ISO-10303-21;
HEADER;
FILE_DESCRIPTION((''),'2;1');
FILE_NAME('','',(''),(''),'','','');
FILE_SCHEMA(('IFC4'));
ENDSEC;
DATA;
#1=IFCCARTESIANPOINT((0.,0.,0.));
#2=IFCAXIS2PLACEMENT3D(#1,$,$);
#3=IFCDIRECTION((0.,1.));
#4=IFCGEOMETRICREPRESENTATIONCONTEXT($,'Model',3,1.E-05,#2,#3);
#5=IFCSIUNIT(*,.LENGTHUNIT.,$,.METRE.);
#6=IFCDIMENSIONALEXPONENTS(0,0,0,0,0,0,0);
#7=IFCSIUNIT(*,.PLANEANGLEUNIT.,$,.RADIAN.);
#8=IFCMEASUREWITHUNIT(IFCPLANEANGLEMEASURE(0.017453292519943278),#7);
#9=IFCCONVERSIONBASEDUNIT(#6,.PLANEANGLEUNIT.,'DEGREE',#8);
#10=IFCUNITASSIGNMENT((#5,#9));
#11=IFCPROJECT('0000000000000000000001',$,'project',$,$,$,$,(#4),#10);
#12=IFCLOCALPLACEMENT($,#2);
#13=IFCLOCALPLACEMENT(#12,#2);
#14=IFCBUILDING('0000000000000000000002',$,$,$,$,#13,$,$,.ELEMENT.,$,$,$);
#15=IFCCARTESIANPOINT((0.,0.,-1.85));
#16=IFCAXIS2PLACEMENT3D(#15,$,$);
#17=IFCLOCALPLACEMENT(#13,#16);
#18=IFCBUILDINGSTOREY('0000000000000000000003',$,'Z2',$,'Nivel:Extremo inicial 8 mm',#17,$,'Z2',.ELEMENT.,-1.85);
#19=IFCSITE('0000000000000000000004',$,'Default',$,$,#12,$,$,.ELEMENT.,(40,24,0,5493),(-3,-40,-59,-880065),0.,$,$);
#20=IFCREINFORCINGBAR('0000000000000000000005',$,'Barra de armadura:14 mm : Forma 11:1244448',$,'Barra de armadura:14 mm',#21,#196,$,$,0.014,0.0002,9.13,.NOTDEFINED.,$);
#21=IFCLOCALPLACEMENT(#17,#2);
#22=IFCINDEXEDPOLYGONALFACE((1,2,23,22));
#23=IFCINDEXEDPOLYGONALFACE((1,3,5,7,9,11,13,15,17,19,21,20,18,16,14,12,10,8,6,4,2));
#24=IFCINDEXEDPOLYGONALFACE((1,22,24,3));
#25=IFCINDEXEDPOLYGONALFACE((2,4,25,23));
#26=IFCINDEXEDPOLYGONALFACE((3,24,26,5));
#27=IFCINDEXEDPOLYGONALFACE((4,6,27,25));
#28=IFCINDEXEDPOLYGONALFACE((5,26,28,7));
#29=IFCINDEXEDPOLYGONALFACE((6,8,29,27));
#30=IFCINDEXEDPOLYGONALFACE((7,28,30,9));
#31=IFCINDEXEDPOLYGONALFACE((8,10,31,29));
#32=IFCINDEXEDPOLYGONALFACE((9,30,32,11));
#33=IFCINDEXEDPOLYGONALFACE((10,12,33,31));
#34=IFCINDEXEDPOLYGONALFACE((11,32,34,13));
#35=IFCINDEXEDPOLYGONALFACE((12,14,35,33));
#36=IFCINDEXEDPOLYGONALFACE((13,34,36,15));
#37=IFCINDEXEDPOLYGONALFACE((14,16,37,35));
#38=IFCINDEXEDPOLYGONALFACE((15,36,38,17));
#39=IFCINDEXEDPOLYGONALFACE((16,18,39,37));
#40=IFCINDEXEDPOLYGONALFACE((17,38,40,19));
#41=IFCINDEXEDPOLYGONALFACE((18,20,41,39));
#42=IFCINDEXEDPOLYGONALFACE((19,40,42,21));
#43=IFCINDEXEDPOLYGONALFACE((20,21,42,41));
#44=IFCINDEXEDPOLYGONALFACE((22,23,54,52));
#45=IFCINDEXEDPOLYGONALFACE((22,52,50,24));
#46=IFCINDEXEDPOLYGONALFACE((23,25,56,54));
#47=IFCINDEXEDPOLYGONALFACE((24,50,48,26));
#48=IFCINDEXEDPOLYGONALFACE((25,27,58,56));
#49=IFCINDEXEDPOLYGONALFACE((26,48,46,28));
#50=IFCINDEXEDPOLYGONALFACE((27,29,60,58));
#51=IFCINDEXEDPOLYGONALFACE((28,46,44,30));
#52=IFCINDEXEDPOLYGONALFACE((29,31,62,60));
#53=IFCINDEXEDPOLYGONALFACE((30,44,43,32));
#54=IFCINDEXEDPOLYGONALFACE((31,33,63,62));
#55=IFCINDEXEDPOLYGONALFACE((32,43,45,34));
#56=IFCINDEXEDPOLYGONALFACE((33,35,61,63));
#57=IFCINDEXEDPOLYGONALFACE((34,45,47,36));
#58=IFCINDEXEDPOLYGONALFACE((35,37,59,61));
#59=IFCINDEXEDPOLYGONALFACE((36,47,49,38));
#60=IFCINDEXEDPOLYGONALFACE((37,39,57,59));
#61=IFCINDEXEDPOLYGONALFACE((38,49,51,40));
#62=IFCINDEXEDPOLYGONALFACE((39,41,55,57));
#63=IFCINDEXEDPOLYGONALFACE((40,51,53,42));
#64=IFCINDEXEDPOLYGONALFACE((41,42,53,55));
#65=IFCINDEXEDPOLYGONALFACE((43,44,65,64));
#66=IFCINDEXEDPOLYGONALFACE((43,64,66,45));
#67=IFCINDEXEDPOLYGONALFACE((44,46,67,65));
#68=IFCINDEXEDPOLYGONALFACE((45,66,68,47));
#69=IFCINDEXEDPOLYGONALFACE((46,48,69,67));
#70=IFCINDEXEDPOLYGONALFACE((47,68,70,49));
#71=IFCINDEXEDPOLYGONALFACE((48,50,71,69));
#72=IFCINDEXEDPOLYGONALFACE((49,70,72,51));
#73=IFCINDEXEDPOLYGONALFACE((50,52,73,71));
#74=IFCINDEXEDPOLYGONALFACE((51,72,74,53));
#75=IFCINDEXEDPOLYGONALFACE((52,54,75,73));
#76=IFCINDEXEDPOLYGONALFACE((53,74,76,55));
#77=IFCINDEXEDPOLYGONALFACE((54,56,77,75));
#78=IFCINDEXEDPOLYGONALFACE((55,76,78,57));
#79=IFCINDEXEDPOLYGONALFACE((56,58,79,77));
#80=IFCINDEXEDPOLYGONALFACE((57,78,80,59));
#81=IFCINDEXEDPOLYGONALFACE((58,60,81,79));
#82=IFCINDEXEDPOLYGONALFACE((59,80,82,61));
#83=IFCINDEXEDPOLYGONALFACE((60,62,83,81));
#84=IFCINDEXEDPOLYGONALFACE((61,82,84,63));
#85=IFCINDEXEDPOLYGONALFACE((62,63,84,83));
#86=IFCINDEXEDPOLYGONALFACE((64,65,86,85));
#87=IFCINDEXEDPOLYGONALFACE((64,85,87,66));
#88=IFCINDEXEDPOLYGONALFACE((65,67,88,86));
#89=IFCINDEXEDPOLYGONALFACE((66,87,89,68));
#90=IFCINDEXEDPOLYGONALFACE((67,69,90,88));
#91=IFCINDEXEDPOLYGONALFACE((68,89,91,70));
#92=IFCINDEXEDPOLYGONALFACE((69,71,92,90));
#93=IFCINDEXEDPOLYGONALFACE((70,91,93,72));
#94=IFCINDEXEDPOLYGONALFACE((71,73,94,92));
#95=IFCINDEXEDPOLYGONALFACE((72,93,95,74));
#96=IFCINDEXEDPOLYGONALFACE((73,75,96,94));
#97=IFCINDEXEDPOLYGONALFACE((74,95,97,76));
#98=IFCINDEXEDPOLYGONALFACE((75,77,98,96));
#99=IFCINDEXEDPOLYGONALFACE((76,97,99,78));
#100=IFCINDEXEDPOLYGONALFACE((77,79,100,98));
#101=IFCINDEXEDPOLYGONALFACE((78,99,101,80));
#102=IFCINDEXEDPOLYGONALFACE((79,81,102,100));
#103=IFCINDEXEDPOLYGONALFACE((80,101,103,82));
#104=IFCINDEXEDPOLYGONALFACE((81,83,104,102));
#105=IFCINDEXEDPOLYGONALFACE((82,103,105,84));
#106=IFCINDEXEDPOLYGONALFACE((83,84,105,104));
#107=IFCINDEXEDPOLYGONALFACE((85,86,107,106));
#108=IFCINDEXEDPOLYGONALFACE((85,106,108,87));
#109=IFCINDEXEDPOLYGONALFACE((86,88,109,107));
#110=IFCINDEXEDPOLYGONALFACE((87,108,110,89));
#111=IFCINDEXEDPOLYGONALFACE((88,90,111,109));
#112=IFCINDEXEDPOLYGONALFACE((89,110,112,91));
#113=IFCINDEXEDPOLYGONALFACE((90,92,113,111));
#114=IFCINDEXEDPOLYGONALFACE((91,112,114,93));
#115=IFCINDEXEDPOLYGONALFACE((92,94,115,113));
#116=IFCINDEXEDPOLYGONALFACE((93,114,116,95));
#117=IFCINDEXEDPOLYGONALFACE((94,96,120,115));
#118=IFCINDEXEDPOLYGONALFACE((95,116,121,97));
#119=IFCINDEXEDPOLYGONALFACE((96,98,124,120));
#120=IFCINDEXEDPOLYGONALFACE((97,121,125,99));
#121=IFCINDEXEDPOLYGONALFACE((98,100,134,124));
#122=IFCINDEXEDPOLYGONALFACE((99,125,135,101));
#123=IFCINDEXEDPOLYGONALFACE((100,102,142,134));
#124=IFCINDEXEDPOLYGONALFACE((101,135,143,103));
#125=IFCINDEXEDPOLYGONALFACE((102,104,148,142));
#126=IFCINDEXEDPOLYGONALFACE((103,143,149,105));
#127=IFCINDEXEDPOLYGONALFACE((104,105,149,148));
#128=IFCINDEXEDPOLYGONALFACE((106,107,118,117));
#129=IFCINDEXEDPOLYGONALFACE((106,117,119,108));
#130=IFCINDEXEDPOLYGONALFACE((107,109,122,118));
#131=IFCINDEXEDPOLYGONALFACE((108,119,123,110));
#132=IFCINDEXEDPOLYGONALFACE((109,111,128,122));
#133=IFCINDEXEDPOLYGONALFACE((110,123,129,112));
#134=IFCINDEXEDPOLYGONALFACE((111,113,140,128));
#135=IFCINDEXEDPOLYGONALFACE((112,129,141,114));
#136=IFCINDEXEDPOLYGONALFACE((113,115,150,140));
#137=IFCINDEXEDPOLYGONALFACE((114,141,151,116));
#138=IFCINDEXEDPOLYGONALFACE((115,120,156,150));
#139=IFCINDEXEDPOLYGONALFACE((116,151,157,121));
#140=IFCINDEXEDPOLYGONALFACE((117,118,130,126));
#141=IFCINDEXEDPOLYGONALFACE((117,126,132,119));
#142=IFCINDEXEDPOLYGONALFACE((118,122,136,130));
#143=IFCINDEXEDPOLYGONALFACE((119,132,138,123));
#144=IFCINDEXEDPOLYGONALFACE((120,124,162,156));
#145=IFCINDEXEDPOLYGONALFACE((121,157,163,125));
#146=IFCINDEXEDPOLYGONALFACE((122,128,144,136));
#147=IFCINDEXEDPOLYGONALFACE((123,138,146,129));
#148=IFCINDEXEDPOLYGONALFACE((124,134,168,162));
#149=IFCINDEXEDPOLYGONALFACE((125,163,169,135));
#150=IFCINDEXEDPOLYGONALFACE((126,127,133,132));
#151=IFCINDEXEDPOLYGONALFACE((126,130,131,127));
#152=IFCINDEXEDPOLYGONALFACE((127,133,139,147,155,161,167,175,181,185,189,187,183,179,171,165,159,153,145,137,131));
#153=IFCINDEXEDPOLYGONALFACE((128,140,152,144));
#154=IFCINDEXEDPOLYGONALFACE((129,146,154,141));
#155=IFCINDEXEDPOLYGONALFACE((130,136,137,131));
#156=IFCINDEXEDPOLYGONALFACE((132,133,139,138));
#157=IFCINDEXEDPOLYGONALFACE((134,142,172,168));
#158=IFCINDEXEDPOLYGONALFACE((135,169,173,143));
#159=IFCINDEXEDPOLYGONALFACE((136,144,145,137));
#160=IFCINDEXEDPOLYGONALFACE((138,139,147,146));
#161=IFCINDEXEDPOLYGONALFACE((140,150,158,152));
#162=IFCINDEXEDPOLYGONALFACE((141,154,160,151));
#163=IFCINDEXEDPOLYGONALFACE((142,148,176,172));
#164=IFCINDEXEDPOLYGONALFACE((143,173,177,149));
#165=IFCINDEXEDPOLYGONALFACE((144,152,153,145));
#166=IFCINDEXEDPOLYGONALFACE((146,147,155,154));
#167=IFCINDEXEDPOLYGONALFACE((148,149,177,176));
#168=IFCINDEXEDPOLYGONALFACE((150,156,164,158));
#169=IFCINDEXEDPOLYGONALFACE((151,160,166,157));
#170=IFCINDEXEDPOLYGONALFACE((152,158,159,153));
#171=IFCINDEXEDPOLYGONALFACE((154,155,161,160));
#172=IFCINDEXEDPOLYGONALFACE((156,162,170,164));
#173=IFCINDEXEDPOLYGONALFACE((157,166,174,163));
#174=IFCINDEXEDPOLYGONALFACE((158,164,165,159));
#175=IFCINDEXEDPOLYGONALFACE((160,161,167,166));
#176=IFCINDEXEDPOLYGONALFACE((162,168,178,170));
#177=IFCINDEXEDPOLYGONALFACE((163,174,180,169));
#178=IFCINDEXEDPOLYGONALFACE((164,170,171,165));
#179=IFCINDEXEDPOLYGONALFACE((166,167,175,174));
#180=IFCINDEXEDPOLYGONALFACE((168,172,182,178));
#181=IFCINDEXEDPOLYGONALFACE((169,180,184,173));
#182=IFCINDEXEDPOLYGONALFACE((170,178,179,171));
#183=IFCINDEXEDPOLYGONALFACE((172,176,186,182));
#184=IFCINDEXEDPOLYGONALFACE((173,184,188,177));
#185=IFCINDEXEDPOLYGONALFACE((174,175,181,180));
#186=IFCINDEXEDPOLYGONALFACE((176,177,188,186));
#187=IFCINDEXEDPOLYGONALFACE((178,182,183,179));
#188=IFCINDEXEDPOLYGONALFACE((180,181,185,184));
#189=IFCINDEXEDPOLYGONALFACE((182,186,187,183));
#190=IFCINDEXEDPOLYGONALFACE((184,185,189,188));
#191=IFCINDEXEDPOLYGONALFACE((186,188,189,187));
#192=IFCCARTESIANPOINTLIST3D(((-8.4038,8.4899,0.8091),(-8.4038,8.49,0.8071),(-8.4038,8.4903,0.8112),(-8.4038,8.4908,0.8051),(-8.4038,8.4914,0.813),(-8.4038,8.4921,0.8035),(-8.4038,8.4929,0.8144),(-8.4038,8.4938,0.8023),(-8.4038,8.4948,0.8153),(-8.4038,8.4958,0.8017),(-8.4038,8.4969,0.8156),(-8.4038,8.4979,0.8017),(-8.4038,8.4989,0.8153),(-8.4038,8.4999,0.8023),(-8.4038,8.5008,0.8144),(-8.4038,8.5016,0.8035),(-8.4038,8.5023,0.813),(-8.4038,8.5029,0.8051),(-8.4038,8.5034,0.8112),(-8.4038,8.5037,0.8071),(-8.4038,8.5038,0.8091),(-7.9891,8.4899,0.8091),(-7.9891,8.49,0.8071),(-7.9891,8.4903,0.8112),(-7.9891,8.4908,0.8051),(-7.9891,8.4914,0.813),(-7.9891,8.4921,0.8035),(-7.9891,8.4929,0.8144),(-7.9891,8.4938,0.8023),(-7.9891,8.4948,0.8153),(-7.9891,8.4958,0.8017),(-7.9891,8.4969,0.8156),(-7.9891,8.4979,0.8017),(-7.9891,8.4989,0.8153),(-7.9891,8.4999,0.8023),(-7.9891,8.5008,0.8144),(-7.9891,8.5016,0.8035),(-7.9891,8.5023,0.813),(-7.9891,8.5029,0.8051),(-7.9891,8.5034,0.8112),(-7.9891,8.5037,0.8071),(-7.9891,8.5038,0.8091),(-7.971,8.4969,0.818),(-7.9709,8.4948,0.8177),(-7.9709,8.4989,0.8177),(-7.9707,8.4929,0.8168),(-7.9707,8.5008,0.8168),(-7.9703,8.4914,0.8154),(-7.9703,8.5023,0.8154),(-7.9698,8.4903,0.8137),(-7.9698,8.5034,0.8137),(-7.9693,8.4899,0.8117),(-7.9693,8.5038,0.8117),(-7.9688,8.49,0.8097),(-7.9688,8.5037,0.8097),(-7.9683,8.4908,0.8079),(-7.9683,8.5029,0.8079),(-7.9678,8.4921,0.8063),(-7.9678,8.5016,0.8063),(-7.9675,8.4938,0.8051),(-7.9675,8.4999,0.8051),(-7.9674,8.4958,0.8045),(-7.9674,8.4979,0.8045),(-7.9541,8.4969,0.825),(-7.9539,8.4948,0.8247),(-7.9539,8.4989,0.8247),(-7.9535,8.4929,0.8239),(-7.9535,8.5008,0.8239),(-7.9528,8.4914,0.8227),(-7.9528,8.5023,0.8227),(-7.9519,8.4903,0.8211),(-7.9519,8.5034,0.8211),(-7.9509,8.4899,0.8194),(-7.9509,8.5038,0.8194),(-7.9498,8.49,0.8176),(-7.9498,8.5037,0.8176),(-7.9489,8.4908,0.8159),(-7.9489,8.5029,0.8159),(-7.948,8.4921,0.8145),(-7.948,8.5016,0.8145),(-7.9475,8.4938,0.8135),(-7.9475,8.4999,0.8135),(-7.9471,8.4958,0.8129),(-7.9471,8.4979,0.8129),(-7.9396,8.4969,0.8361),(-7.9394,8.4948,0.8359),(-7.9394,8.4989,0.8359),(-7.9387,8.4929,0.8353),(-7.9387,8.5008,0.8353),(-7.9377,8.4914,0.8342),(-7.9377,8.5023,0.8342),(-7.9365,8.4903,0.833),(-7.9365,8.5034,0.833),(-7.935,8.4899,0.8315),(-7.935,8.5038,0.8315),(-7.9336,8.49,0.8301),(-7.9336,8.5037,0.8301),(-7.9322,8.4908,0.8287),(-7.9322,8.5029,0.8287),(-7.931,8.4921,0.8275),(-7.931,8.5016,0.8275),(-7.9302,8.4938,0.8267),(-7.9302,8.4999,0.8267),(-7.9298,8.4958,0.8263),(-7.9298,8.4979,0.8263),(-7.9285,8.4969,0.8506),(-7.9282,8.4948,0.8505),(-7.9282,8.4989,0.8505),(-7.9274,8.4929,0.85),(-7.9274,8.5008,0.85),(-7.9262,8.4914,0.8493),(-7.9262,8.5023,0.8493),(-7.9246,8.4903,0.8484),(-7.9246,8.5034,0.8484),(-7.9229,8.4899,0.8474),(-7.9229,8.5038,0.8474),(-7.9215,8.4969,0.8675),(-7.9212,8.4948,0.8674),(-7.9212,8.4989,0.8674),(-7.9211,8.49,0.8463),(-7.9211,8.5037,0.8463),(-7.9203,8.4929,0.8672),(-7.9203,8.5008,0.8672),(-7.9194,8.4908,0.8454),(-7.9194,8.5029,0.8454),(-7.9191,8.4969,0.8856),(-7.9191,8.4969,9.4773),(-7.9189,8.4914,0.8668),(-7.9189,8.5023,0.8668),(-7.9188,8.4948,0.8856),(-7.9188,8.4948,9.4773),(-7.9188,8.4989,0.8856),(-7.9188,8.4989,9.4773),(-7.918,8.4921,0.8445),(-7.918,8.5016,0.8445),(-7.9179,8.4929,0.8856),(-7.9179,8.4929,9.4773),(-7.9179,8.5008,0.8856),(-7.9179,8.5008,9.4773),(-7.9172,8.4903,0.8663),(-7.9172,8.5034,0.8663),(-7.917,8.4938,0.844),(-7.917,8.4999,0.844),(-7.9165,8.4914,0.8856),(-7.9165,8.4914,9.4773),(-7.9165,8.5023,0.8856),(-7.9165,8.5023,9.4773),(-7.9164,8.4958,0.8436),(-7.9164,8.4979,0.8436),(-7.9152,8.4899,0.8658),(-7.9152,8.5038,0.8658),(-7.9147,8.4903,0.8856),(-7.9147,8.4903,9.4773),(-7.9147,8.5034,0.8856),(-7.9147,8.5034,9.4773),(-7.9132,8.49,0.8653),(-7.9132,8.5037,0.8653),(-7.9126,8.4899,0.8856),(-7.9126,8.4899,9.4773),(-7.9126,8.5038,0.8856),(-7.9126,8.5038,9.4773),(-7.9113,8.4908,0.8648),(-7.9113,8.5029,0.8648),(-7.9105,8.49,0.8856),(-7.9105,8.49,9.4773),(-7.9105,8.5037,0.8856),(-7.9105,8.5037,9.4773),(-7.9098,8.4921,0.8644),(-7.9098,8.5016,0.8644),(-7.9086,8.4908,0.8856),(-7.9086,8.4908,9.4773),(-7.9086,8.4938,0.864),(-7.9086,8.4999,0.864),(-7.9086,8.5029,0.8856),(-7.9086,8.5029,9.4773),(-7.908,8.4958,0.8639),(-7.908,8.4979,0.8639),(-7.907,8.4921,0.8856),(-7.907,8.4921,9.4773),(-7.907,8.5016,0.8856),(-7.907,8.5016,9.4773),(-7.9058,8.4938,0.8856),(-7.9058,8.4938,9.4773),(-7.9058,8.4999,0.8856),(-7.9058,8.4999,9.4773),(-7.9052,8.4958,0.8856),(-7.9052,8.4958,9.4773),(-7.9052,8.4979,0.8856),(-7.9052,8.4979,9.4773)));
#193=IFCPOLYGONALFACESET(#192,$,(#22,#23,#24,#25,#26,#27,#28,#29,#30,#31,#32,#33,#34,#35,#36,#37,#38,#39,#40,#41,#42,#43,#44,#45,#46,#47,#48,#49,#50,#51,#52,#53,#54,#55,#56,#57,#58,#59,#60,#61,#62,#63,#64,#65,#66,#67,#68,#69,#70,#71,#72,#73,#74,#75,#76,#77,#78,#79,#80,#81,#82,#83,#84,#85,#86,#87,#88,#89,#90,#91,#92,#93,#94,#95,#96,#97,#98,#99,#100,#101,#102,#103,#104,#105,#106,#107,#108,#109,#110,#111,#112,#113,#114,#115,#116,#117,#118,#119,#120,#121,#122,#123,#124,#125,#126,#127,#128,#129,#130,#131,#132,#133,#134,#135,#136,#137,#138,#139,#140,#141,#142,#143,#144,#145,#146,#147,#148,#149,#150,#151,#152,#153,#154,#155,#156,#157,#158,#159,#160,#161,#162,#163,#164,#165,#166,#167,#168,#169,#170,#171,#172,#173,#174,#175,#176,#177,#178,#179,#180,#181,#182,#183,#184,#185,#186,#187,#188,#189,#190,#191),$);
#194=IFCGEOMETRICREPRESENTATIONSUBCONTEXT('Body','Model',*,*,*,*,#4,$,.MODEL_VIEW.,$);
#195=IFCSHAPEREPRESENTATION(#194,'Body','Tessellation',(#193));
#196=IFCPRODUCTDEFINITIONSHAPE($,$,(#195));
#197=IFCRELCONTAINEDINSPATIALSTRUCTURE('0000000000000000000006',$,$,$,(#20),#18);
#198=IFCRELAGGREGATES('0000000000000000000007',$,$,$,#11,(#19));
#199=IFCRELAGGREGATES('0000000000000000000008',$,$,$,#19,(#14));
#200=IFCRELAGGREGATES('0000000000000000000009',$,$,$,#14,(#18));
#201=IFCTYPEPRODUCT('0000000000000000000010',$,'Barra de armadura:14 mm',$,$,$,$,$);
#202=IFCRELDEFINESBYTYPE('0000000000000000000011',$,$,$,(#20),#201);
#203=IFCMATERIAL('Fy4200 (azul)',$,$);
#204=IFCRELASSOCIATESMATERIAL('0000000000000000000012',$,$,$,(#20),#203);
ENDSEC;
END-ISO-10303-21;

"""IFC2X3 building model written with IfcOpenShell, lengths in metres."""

from ifc_helpers import new_model, entity, si_unit, converted_unit, direction, frame, origin, place, context, subcontext, project, spatial, material, type_object, element, save


model = new_model("IFC2X3")

# Units and contexts
model_context = context("Model", 3, precision=1e-05, world=origin(), true_north=direction((0.0, 1.0)))
body_context = subcontext(model_context, "Body", "Model", "MODEL_VIEW")
ifc_project = project(units=[si_unit("LENGTHUNIT", "METRE"), converted_unit("PLANEANGLEUNIT", "DEGREE", entity("IfcPlaneAngleMeasure", 0.017453292519943278), si_unit("PLANEANGLEUNIT", "RADIAN"), dimensions=[0, 0, 0, 0, 0, 0, 0])], contexts=[model_context])

# Site, building, storey
site_placement = place(None, origin())
site = spatial("IfcSite", under=ifc_project, at=site_placement, Name="Default", CompositionType="ELEMENT", RefLatitude=(40, 24, 0, 5493), RefLongitude=(-3, -40, -59, -880065), RefElevation=0.0)
building_placement = place(site_placement, origin())
building = spatial("IfcBuilding", under=site, at=building_placement, CompositionType="ELEMENT")
storey_placement = place(building_placement, frame((0.0, 0.0, -1.85)))
storey = spatial("IfcBuildingStorey", under=building, at=storey_placement, Name="Z2", ObjectType="Nivel:Extremo inicial 8 mm", LongName="Z2", CompositionType="ELEMENT", Elevation=-1.85)

# Reinforcing bar
ifc_material_1 = material(Name="Fy4200 (azul)")
type_product_1 = type_object("IfcTypeProduct", Name="Barra de armadura:14 mm")
reinforcing_bar_1_placement = place(storey_placement, origin())
element("IfcReinforcingBar", 1, at=reinforcing_bar_1_placement, inside=storey, type_object=type_product_1, material=ifc_material_1, Name="Barra de armadura:14 mm : Forma 11:1244448", ObjectType="Barra de armadura:14 mm", BarLength=9.13, BarRole="NOTDEFINED", CrossSectionArea=0.0002, NominalDiameter=0.014, context=body_context, shape_type="AdvancedSweptSolid", body=[
    entity("IfcSweptDiskSolid", entity("IfcCompositeCurve", [entity("IfcCompositeCurveSegment", "CONTINUOUS", True, entity("IfcPolyline", [entity("IfcCartesianPoint", [-7.9121, 8.4969, 9.4773]), entity("IfcCartesianPoint", [-7.9121, 8.4969, 0.8856])])), entity("IfcCompositeCurveSegment", "CONTINUOUS", True, entity("IfcTrimmedCurve", entity("IfcCircle", entity("IfcAxis2Placement3D", entity("IfcCartesianPoint", [-7.9891, 8.4969, 0.8856]), entity("IfcDirection", [0.0, 1.0, 0.0]), entity("IfcDirection", [0.0, 0.0, -1.0])), 0.077), [entity("IfcParameterValue", 270.0)], [entity("IfcParameterValue", 360.0)], True, "PARAMETER")), entity("IfcCompositeCurveSegment", "CONTINUOUS", True, entity("IfcPolyline", [entity("IfcCartesianPoint", [-7.9891, 8.4969, 0.8086]), entity("IfcCartesianPoint", [-8.4038, 8.4969, 0.8086])]))], False), 0.007, None, 0.0, 92.0),
])

save(model, "model.ifc")
